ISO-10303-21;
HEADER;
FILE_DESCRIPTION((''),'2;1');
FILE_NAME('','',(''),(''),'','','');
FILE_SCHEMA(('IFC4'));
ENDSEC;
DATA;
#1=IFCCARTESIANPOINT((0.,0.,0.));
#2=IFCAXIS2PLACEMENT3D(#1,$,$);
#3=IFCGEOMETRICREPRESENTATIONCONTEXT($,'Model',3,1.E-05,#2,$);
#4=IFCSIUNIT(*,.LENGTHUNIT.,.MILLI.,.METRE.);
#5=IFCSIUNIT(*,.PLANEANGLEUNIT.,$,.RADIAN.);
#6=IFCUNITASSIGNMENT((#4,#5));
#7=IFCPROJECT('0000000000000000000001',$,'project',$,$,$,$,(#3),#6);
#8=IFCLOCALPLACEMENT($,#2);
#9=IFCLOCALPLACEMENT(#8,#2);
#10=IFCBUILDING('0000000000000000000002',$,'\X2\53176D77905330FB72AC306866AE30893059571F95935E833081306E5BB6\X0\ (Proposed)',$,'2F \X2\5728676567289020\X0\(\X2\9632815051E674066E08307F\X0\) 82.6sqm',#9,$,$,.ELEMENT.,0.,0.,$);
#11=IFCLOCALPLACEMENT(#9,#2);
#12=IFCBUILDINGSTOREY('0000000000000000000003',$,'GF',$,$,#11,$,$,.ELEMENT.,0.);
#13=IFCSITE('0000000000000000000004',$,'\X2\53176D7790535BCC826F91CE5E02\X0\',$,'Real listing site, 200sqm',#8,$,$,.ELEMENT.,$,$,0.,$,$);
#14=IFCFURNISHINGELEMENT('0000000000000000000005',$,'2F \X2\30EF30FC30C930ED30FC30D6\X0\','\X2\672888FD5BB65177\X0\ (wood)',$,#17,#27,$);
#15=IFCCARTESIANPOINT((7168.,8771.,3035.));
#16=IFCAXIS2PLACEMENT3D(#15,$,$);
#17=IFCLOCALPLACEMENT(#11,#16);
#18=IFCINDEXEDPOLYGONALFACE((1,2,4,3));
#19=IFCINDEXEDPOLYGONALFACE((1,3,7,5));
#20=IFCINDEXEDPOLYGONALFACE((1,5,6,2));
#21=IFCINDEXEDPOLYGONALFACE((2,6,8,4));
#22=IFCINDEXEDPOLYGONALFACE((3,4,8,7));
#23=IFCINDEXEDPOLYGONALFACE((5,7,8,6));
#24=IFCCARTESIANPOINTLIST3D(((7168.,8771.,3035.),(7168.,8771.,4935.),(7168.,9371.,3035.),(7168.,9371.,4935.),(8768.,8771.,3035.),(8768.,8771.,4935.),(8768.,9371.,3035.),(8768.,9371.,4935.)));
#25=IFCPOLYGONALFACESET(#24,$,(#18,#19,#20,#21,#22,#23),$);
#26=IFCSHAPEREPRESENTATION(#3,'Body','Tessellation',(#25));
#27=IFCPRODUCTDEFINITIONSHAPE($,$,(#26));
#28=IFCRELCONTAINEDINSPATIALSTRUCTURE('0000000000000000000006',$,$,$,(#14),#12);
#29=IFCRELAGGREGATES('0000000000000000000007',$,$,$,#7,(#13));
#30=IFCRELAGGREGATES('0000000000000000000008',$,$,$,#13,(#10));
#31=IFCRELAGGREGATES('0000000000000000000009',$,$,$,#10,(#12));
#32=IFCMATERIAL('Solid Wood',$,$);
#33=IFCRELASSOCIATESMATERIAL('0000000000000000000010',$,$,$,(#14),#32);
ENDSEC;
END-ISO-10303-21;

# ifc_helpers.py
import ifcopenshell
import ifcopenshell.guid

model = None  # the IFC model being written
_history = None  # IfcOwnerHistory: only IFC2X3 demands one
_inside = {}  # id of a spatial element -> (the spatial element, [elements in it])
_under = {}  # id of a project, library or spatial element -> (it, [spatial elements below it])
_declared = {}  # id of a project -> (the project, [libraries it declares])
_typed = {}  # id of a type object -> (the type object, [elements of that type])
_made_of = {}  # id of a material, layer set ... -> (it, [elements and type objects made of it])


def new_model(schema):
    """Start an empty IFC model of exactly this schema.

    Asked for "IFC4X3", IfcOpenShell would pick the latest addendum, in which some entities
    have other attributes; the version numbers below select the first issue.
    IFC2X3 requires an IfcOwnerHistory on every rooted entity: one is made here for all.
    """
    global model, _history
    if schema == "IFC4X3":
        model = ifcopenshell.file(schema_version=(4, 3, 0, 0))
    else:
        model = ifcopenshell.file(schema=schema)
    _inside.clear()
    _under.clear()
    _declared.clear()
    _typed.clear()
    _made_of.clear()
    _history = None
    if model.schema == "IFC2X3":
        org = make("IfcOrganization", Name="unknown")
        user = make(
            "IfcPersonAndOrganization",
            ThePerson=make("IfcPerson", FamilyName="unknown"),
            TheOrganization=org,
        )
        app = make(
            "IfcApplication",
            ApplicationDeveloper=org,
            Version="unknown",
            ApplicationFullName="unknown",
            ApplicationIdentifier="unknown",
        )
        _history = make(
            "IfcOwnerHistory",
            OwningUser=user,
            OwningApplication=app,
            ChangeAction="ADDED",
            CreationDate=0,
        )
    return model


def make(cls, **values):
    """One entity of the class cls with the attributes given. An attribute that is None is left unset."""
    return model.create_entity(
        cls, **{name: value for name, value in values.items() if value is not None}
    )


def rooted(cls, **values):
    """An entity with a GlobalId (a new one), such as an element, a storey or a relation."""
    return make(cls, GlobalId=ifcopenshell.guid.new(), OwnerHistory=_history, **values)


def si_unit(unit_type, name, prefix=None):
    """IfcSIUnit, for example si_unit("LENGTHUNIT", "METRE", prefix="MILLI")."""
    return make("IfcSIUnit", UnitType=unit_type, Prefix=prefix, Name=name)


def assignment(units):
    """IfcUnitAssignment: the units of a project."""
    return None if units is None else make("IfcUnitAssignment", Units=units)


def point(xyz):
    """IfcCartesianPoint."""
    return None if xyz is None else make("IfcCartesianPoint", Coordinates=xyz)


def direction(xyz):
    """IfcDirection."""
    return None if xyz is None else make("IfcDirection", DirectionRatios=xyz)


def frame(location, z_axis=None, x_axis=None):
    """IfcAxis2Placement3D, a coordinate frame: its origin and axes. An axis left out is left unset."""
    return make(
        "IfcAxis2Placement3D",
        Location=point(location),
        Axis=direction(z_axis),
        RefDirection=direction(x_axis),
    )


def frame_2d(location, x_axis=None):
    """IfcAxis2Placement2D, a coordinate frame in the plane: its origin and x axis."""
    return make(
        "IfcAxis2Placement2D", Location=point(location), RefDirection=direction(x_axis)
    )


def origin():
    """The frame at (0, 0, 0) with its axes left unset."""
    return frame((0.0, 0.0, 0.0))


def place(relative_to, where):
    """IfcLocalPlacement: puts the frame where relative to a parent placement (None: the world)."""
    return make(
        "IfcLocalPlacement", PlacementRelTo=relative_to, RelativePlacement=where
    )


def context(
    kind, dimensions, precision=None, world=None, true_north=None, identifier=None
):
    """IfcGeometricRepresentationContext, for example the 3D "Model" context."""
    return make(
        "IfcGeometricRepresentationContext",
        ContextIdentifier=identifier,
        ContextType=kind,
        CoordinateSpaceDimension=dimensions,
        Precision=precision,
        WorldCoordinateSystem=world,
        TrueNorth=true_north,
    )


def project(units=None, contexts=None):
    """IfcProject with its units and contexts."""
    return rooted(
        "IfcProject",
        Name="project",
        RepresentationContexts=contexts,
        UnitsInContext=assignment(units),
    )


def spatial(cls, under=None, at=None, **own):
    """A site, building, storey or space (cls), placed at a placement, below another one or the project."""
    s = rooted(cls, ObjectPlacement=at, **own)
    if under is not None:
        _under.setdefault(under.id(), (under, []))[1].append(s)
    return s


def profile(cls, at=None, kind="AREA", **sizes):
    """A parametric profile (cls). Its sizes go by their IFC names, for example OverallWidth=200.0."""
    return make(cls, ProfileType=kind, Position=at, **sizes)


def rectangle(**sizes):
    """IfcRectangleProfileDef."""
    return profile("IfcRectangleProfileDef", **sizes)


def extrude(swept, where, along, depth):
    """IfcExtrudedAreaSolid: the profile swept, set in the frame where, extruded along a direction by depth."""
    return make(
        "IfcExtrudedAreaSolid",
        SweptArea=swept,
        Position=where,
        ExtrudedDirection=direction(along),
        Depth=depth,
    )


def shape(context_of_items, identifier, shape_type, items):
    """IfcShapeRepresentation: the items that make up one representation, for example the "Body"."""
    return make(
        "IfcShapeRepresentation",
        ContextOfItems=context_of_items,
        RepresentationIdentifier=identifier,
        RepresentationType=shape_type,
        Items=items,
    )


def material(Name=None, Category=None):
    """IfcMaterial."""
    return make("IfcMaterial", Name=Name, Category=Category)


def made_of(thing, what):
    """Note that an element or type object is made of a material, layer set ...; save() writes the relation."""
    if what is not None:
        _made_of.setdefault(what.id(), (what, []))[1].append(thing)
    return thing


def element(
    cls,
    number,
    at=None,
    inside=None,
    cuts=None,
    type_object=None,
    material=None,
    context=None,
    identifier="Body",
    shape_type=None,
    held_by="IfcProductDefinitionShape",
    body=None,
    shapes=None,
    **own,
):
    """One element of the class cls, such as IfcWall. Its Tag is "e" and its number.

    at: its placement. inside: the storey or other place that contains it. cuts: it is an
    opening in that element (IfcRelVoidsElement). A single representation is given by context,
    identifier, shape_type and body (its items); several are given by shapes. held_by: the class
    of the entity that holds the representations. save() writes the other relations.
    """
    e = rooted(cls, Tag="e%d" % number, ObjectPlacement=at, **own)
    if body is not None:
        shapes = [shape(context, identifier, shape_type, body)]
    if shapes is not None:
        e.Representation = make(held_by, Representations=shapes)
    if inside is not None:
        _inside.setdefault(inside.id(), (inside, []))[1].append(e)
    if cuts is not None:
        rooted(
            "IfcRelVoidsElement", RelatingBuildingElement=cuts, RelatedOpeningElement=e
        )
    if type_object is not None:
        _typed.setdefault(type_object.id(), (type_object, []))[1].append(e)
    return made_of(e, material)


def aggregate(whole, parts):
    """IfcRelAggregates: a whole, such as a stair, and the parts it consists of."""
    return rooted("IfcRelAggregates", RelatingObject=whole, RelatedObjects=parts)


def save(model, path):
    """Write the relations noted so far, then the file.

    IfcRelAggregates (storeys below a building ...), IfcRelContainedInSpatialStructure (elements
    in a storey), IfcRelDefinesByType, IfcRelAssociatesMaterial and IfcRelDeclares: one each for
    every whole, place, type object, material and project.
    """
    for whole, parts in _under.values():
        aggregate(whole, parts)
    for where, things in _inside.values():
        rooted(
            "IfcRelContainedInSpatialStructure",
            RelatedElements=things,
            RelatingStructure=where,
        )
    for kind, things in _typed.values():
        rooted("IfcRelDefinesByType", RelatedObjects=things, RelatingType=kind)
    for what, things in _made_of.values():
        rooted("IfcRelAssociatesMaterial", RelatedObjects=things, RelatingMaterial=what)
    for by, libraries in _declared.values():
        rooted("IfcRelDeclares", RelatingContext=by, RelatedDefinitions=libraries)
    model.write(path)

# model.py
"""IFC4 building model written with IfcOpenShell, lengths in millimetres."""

from ifc_helpers import new_model, si_unit, frame, frame_2d, origin, place, context, project, spatial, rectangle, extrude, material, element, save


model = new_model("IFC4")

# Units and contexts
model_context = context("Model", 3, precision=1e-05, world=origin())
ifc_project = project(units=[si_unit("LENGTHUNIT", "METRE", prefix="MILLI"), si_unit("PLANEANGLEUNIT", "RADIAN")], contexts=[model_context])

# Site, building, storey
site_placement = place(None, origin())
site = spatial("IfcSite", under=ifc_project, at=site_placement, Name="北海道富良野市", ObjectType="Real listing site, 200sqm", CompositionType="ELEMENT", RefElevation=0.0)
building_placement = place(site_placement, origin())
building = spatial("IfcBuilding", under=site, at=building_placement, Name="北海道・犬と暮らす土間広めの家 (Proposed)", ObjectType="2F 在来木造(防腐処理済み) 82.6sqm", CompositionType="ELEMENT", ElevationOfRefHeight=0.0, ElevationOfTerrain=0.0)
storey_placement = place(building_placement, origin())
storey = spatial("IfcBuildingStorey", under=building, at=storey_placement, Name="GF", CompositionType="ELEMENT", Elevation=0.0)

# Shared definitions
ifc_material_1 = material(Name="Solid Wood")

# Furnishing element
furnishing_1_placement = place(storey_placement, frame((7168.0, 8771.0, 3035.0)))
element("IfcFurnishingElement", 1, at=furnishing_1_placement, inside=storey, material=ifc_material_1, Name="2F ワードローブ", Description="木製家具 (wood)", context=model_context, shape_type="SweptSolid", body=[
    extrude(rectangle(XDim=1600.0, YDim=600.0, at=frame_2d((800.0, 300.0))), frame((7168.0, 8771.0, 3035.0)), (0.0, 0.0, 1.0), 1900.0),
])

save(model, "model.ifc")
